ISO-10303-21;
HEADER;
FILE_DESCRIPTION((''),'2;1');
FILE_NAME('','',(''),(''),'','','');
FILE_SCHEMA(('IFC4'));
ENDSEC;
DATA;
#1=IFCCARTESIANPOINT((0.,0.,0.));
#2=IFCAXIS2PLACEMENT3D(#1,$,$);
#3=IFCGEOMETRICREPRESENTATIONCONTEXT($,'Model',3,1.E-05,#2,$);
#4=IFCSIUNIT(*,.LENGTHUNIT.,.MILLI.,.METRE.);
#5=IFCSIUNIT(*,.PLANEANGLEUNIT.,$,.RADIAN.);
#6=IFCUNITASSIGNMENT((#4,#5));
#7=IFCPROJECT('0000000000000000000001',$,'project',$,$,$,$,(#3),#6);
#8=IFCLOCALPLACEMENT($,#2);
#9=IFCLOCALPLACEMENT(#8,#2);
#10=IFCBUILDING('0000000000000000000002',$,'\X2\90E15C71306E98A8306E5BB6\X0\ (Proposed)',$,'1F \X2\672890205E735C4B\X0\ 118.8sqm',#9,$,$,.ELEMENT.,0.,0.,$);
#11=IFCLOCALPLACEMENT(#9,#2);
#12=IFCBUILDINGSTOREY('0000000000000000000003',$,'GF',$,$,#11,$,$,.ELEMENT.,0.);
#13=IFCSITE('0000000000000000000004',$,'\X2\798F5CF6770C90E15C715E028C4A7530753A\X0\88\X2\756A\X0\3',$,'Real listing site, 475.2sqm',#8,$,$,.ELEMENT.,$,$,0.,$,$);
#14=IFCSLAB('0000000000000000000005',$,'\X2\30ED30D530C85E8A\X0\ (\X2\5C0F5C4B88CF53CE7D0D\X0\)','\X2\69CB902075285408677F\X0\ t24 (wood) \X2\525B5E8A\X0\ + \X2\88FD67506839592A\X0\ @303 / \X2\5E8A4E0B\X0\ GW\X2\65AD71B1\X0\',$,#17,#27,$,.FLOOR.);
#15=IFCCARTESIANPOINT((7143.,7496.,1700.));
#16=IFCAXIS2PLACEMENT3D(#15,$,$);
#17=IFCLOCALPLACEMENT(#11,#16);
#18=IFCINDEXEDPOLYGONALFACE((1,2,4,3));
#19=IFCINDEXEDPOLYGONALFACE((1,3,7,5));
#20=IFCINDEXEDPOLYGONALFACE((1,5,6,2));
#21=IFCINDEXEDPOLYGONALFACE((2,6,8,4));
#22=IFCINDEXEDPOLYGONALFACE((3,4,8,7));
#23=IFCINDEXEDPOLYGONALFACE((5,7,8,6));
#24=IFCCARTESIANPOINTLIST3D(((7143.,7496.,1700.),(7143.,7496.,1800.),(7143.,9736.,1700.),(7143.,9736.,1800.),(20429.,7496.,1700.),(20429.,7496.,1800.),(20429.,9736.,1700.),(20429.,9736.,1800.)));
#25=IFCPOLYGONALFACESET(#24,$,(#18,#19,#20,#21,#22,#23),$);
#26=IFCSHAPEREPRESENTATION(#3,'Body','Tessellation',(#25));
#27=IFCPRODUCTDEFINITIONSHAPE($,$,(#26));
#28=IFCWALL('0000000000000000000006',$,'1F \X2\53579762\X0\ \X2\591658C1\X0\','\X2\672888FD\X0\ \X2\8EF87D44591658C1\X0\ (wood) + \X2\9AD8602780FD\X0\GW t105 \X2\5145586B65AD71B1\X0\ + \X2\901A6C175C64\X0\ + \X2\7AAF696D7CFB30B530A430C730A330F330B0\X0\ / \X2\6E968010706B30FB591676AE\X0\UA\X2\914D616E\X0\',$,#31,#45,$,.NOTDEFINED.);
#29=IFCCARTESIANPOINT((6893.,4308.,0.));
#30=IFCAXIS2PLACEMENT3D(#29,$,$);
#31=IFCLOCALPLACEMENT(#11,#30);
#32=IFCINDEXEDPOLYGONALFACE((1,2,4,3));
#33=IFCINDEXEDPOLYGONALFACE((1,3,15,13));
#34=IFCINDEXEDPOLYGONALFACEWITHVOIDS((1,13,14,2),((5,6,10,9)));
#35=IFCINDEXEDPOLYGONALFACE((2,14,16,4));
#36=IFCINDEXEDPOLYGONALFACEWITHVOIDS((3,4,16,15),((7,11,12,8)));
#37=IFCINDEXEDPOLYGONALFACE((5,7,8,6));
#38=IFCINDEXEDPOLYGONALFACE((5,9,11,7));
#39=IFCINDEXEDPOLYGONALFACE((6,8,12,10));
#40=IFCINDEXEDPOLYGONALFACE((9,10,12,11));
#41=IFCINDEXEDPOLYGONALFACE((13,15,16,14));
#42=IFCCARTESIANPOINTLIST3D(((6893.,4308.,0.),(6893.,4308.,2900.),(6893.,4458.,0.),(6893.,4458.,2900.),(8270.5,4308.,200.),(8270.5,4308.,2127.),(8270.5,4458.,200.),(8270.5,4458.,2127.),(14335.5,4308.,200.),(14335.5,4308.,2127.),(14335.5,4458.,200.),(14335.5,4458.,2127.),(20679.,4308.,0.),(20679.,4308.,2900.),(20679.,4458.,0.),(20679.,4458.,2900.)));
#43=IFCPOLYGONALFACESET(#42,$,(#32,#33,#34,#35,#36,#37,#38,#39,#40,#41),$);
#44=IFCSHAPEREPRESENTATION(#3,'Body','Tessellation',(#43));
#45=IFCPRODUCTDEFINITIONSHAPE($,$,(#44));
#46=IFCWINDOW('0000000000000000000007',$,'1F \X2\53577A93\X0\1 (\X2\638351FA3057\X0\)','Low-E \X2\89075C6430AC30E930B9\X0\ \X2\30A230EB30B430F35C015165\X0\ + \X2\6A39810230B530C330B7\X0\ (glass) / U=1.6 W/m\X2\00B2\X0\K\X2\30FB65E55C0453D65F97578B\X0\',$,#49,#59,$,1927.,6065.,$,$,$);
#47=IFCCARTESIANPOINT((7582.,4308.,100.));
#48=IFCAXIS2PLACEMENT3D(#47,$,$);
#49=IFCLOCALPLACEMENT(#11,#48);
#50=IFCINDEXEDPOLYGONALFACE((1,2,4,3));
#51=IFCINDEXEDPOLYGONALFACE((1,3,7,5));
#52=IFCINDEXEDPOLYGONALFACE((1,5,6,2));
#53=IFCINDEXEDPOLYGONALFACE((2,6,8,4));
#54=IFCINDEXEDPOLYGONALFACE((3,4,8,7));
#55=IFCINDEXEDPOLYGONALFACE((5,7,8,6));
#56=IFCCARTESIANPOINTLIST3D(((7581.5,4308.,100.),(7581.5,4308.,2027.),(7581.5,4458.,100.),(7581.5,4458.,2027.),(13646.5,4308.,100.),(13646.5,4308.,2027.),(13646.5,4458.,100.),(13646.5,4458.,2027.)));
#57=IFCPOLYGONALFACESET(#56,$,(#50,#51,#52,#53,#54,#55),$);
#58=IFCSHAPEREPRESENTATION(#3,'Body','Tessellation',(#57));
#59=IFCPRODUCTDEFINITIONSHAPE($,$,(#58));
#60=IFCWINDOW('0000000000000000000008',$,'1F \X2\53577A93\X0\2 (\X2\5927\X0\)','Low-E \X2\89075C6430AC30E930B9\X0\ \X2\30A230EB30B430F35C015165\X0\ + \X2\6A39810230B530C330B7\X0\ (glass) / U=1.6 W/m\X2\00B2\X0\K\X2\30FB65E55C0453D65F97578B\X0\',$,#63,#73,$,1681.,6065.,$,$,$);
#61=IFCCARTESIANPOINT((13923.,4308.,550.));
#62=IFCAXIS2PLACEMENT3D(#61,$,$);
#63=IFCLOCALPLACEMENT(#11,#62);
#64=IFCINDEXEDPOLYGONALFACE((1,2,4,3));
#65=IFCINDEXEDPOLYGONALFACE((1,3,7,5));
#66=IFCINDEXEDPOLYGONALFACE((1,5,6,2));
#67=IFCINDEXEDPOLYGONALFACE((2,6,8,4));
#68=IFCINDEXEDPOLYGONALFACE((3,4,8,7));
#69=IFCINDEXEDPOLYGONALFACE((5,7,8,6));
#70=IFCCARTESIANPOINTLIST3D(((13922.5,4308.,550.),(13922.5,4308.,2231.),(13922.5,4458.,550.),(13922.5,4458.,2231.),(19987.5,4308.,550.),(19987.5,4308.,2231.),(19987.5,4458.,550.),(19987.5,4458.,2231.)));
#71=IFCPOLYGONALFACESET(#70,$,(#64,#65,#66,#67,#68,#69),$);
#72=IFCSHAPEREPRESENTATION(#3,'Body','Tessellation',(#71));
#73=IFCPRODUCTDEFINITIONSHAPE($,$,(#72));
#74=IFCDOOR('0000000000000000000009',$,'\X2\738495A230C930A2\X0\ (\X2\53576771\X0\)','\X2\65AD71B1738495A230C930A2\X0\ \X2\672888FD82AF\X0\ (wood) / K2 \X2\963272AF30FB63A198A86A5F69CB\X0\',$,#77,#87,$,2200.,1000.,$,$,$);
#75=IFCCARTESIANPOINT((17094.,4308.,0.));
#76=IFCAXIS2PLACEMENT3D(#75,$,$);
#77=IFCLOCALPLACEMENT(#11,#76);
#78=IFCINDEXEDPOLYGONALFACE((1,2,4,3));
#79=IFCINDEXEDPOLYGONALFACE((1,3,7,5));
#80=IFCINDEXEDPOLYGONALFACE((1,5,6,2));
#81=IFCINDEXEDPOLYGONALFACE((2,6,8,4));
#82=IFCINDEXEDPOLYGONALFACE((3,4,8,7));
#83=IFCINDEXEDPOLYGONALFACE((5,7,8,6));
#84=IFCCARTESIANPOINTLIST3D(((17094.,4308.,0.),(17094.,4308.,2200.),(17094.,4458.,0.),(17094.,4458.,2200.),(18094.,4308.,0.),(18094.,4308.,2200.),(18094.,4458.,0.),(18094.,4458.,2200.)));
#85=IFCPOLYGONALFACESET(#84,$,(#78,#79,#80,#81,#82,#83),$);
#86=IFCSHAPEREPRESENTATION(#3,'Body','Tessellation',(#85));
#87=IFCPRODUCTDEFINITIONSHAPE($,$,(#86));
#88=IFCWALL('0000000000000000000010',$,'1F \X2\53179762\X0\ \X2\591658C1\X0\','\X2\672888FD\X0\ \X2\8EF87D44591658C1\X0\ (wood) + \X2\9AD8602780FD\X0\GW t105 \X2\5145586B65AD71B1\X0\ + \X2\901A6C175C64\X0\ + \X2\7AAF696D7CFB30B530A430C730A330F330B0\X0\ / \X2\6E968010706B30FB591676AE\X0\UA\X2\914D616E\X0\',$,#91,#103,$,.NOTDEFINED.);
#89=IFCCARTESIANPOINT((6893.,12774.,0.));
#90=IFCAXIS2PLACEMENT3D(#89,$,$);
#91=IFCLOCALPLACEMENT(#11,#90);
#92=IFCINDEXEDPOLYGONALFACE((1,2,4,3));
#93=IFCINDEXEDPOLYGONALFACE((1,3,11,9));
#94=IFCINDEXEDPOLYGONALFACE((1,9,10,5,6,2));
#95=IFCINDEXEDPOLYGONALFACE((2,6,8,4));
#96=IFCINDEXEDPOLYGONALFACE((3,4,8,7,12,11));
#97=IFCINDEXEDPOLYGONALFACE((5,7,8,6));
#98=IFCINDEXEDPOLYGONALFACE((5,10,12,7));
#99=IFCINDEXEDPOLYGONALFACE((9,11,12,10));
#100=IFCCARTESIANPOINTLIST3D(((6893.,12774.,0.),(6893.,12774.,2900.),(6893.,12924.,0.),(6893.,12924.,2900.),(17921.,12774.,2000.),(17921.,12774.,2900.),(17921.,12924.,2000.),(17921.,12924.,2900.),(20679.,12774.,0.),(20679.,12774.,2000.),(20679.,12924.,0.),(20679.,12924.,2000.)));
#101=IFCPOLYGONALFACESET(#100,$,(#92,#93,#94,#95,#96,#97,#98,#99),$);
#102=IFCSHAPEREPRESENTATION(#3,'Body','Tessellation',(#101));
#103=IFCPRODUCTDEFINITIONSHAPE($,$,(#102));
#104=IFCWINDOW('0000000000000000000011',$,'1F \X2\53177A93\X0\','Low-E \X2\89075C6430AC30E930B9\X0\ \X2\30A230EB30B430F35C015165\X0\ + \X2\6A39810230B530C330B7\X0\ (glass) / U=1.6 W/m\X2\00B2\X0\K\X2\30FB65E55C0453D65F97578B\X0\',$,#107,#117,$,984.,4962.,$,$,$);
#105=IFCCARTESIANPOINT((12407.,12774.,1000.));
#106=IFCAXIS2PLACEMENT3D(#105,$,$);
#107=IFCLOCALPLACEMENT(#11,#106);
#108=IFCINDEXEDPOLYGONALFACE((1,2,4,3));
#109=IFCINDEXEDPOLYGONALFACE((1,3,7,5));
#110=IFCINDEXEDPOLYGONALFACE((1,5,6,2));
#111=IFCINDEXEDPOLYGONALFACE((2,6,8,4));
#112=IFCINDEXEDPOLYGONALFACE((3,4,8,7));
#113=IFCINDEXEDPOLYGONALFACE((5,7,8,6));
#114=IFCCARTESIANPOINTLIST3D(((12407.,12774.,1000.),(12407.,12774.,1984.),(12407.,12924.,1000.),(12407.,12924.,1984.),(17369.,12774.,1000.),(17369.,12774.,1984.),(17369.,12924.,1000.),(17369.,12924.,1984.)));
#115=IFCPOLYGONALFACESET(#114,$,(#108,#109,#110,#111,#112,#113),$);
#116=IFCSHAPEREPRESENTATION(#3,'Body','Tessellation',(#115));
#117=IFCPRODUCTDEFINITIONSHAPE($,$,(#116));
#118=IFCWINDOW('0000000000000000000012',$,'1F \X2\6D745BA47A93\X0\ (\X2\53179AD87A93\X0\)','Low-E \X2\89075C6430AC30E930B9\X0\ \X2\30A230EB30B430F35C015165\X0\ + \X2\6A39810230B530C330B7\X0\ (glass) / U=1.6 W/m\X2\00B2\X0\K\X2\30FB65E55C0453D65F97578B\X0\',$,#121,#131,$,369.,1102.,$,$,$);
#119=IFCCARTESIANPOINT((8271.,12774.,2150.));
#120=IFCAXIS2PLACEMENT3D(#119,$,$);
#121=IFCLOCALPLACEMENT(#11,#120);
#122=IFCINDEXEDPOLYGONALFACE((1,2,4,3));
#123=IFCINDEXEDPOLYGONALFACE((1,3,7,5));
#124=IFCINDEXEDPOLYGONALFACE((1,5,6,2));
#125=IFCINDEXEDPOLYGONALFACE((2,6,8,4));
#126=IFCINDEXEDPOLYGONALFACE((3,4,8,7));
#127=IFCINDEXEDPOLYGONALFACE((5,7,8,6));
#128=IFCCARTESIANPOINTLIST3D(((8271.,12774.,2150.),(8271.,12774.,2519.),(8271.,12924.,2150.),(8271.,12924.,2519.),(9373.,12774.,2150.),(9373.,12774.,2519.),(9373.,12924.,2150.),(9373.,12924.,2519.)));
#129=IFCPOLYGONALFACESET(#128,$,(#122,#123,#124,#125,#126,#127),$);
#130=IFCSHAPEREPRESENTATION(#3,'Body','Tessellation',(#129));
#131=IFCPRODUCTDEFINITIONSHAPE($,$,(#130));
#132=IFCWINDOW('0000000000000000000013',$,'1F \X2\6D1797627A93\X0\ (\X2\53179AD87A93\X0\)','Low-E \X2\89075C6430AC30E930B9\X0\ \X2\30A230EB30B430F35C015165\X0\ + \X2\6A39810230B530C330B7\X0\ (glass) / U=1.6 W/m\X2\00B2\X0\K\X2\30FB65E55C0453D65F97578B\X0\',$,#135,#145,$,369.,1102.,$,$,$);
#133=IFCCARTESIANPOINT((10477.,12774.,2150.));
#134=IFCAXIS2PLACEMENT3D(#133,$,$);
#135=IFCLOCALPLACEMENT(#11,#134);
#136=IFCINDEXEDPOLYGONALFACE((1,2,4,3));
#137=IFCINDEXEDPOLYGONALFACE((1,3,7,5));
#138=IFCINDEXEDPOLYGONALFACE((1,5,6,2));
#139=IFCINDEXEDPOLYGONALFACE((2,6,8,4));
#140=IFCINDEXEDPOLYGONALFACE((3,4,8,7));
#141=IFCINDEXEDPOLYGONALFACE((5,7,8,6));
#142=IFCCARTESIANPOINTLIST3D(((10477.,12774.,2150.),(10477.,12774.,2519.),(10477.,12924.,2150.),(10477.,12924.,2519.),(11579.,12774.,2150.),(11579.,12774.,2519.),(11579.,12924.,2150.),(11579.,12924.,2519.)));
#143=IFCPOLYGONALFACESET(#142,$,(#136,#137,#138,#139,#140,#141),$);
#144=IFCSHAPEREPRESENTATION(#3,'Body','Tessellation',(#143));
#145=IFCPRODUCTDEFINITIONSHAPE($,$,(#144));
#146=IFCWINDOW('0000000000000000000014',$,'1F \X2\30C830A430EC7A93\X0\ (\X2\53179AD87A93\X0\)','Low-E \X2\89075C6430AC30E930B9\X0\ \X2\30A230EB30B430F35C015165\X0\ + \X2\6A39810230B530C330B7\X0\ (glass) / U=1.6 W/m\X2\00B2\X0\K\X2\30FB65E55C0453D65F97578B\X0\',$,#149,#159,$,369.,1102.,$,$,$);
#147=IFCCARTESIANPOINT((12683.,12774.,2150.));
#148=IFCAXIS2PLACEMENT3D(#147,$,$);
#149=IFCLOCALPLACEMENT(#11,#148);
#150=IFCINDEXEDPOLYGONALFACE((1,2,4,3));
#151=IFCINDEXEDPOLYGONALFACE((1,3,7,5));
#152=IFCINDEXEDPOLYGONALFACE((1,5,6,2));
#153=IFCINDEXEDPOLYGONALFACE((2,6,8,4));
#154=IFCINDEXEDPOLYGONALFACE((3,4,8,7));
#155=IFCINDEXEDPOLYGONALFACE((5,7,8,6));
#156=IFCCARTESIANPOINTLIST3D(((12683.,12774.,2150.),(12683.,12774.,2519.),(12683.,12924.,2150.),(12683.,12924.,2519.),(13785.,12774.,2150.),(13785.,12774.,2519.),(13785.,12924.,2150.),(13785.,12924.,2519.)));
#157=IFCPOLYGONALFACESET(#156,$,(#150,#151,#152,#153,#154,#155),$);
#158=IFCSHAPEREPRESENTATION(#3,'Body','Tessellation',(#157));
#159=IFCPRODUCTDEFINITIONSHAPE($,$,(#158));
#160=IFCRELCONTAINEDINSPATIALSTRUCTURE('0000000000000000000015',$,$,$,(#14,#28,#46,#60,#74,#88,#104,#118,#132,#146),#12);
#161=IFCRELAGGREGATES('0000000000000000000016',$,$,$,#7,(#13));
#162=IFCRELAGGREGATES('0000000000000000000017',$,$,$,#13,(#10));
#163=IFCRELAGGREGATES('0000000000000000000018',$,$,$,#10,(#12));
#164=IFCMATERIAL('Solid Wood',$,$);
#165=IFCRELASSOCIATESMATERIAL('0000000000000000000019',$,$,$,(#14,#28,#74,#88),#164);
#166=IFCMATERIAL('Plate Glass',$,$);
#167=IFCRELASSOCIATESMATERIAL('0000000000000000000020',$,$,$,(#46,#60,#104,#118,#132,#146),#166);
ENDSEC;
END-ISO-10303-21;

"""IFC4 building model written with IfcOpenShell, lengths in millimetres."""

from ifc_helpers import new_model, si_unit, frame, frame_2d, origin, place, context, project, spatial, rectangle, extrude, material, element, fill, save


model = new_model("IFC4")

# Units and contexts
model_context = context("Model", 3, precision=1e-05, world=origin())
ifc_project = project(units=[si_unit("LENGTHUNIT", "METRE", prefix="MILLI"), si_unit("PLANEANGLEUNIT", "RADIAN")], contexts=[model_context])

# Site, building, storey
site_placement = place(None, origin())
site = spatial("IfcSite", under=ifc_project, at=site_placement, Name="福島県郡山市豊田町88番3", ObjectType="Real listing site, 475.2sqm", CompositionType="ELEMENT", RefElevation=0.0)
building_placement = place(site_placement, origin())
building = spatial("IfcBuilding", under=site, at=building_placement, Name="郡山の風の家 (Proposed)", ObjectType="1F 木造平屋 118.8sqm", CompositionType="ELEMENT", ElevationOfRefHeight=0.0, ElevationOfTerrain=0.0)
storey_placement = place(building_placement, origin())
storey = spatial("IfcBuildingStorey", under=building, at=storey_placement, Name="GF", CompositionType="ELEMENT", Elevation=0.0)

# Slab
ifc_material_1 = material(Name="Solid Wood")
slab_1_placement = place(storey_placement, frame((7143.0, 7496.0, 1700.0)))
element("IfcSlab", 1, at=slab_1_placement, inside=storey, material=ifc_material_1, Name="ロフト床 (小屋裏収納)", Description="構造用合板 t24 (wood) 剛床 + 製材根太 @303 / 床下 GW断熱", PredefinedType="FLOOR", context=model_context, shape_type="SweptSolid", body=[
    extrude(rectangle(XDim=13286.0, YDim=2240.0, at=frame_2d((6643.0, 1120.0))), frame((7143.0, 7496.0, 1700.0)), (0.0, 0.0, 1.0), 100.0),
])

# Wall, openings, windows, door
wall_1_placement = place(storey_placement, frame((6893.0, 4308.0, 0.0)))
wall_1 = element("IfcWall", 2, at=wall_1_placement, inside=storey, material=ifc_material_1, Name="1F 南面 外壁", Description="木製 軸組外壁 (wood) + 高性能GW t105 充填断熱 + 通気層 + 窯業系サイディング / 準耐火・外皮UA配慮", PredefinedType="NOTDEFINED", context=model_context, shape_type="SweptSolid", body=[
    extrude(rectangle(XDim=13786.0, YDim=150.0, at=frame_2d((6893.0, 75.0))), frame((6893.0, 4308.0, 0.0)), (0.0, 0.0, 1.0), 2900.0),
])
opening_1_placement = place(storey_placement, frame((7582.0, 4308.0, 100.0)))
opening_1 = element("IfcOpeningElement", 3, at=opening_1_placement, cuts=wall_1, PredefinedType="NOTDEFINED", context=model_context, shape_type="SweptSolid", body=[
    extrude(rectangle(XDim=6065.0, YDim=150.0, at=frame_2d((3032.0, 75.0))), frame((7582.0, 4308.0, 100.0)), (0.0, 0.0, 1.0), 1927.0),
])
opening_2_placement = place(storey_placement, frame((13923.0, 4308.0, 550.0)))
opening_2 = element("IfcOpeningElement", 4, at=opening_2_placement, cuts=wall_1, PredefinedType="NOTDEFINED", context=model_context, shape_type="SweptSolid", body=[
    extrude(rectangle(XDim=6065.0, YDim=150.0, at=frame_2d((3032.0, 75.0))), frame((13923.0, 4308.0, 550.0)), (0.0, 0.0, 1.0), 1681.0),
])
opening_3_placement = place(storey_placement, frame((17094.0, 4308.0, 0.0)))
opening_3 = element("IfcOpeningElement", 5, at=opening_3_placement, cuts=wall_1, PredefinedType="NOTDEFINED", context=model_context, shape_type="SweptSolid", body=[
    extrude(rectangle(XDim=1000.0, YDim=150.0, at=frame_2d((500.0, 75.0))), frame((17094.0, 4308.0, 0.0)), (0.0, 0.0, 1.0), 2200.0),
])
ifc_material_2 = material(Name="Plate Glass")
window_1_placement = place(storey_placement, frame((7582.0, 4308.0, 100.0)))
window_1 = element("IfcWindow", 6, at=window_1_placement, inside=storey, material=ifc_material_2, Name="1F 南窓1 (掃出し)", Description="Low-E 複層ガラス アルゴン封入 + 樹脂サッシ (glass) / U=1.6 W/m²K・日射取得型", OverallHeight=1927.0, OverallWidth=6065.0, context=model_context, shape_type="SweptSolid", body=[
    extrude(rectangle(XDim=6065.0, YDim=150.0, at=frame_2d((3032.0, 75.0))), frame((7582.0, 4308.0, 100.0)), (0.0, 0.0, 1.0), 1927.0),
])
fill(opening_1, window_1)
window_2_placement = place(storey_placement, frame((13923.0, 4308.0, 550.0)))
window_2 = element("IfcWindow", 7, at=window_2_placement, inside=storey, material=ifc_material_2, Name="1F 南窓2 (大)", Description="Low-E 複層ガラス アルゴン封入 + 樹脂サッシ (glass) / U=1.6 W/m²K・日射取得型", OverallHeight=1681.0, OverallWidth=6065.0, context=model_context, shape_type="SweptSolid", body=[
    extrude(rectangle(XDim=6065.0, YDim=150.0, at=frame_2d((3032.0, 75.0))), frame((13923.0, 4308.0, 550.0)), (0.0, 0.0, 1.0), 1681.0),
])
fill(opening_2, window_2)
door_1_placement = place(storey_placement, frame((17094.0, 4308.0, 0.0)))
door_1 = element("IfcDoor", 8, at=door_1_placement, inside=storey, material=ifc_material_1, Name="玄関ドア (南東)", Description="断熱玄関ドア 木製芯 (wood) / K2 防犯・採風機構", OverallHeight=2200.0, OverallWidth=1000.0, context=model_context, shape_type="SweptSolid", body=[
    extrude(rectangle(XDim=1000.0, YDim=150.0, at=frame_2d((500.0, 75.0))), frame((17094.0, 4308.0, 0.0)), (0.0, 0.0, 1.0), 2200.0),
])
fill(opening_3, door_1)

# Wall, openings, windows
wall_2_placement = place(storey_placement, frame((6893.0, 12774.0, 0.0)))
wall_2 = element("IfcWall", 9, at=wall_2_placement, inside=storey, material=ifc_material_1, Name="1F 北面 外壁", Description="木製 軸組外壁 (wood) + 高性能GW t105 充填断熱 + 通気層 + 窯業系サイディング / 準耐火・外皮UA配慮", PredefinedType="NOTDEFINED", context=model_context, shape_type="SweptSolid", body=[
    extrude(rectangle(XDim=13786.0, YDim=150.0, at=frame_2d((6893.0, 75.0))), frame((6893.0, 12774.0, 0.0)), (0.0, 0.0, 1.0), 2900.0),
])
opening_4_placement = place(storey_placement, frame((12407.0, 12774.0, 1000.0)))
opening_4 = element("IfcOpeningElement", 10, at=opening_4_placement, cuts=wall_2, PredefinedType="NOTDEFINED", context=model_context, shape_type="SweptSolid", body=[
    extrude(rectangle(XDim=4962.0, YDim=150.0, at=frame_2d((2481.0, 75.0))), frame((12407.0, 12774.0, 1000.0)), (0.0, 0.0, 1.0), 984.0),
])
opening_5_placement = place(storey_placement, frame((8271.0, 12774.0, 2150.0)))
opening_5 = element("IfcOpeningElement", 11, at=opening_5_placement, cuts=wall_2, PredefinedType="NOTDEFINED", context=model_context, shape_type="SweptSolid", body=[
    extrude(rectangle(XDim=1102.0, YDim=150.0, at=frame_2d((551.0, 75.0))), frame((8271.0, 12774.0, 2150.0)), (0.0, 0.0, 1.0), 369.0),
])
opening_6_placement = place(storey_placement, frame((10477.0, 12774.0, 2150.0)))
opening_6 = element("IfcOpeningElement", 12, at=opening_6_placement, cuts=wall_2, PredefinedType="NOTDEFINED", context=model_context, shape_type="SweptSolid", body=[
    extrude(rectangle(XDim=1102.0, YDim=150.0, at=frame_2d((551.0, 75.0))), frame((10477.0, 12774.0, 2150.0)), (0.0, 0.0, 1.0), 369.0),
])
opening_7_placement = place(storey_placement, frame((12683.0, 12774.0, 2150.0)))
opening_7 = element("IfcOpeningElement", 13, at=opening_7_placement, cuts=wall_2, PredefinedType="NOTDEFINED", context=model_context, shape_type="SweptSolid", body=[
    extrude(rectangle(XDim=1102.0, YDim=150.0, at=frame_2d((551.0, 75.0))), frame((12683.0, 12774.0, 2150.0)), (0.0, 0.0, 1.0), 369.0),
])
window_3_placement = place(storey_placement, frame((12407.0, 12774.0, 1000.0)))
window_3 = element("IfcWindow", 14, at=window_3_placement, inside=storey, material=ifc_material_2, Name="1F 北窓", Description="Low-E 複層ガラス アルゴン封入 + 樹脂サッシ (glass) / U=1.6 W/m²K・日射取得型", OverallHeight=984.0, OverallWidth=4962.0, context=model_context, shape_type="SweptSolid", body=[
    extrude(rectangle(XDim=4962.0, YDim=150.0, at=frame_2d((2481.0, 75.0))), frame((12407.0, 12774.0, 1000.0)), (0.0, 0.0, 1.0), 984.0),
])
fill(opening_4, window_3)
window_4_placement = place(storey_placement, frame((8271.0, 12774.0, 2150.0)))
window_4 = element("IfcWindow", 15, at=window_4_placement, inside=storey, material=ifc_material_2, Name="1F 浴室窓 (北高窓)", Description="Low-E 複層ガラス アルゴン封入 + 樹脂サッシ (glass) / U=1.6 W/m²K・日射取得型", OverallHeight=369.0, OverallWidth=1102.0, context=model_context, shape_type="SweptSolid", body=[
    extrude(rectangle(XDim=1102.0, YDim=150.0, at=frame_2d((551.0, 75.0))), frame((8271.0, 12774.0, 2150.0)), (0.0, 0.0, 1.0), 369.0),
])
fill(opening_5, window_4)
window_5_placement = place(storey_placement, frame((10477.0, 12774.0, 2150.0)))
window_5 = element("IfcWindow", 16, at=window_5_placement, inside=storey, material=ifc_material_2, Name="1F 洗面窓 (北高窓)", Description="Low-E 複層ガラス アルゴン封入 + 樹脂サッシ (glass) / U=1.6 W/m²K・日射取得型", OverallHeight=369.0, OverallWidth=1102.0, context=model_context, shape_type="SweptSolid", body=[
    extrude(rectangle(XDim=1102.0, YDim=150.0, at=frame_2d((551.0, 75.0))), frame((10477.0, 12774.0, 2150.0)), (0.0, 0.0, 1.0), 369.0),
])
fill(opening_6, window_5)
window_6_placement = place(storey_placement, frame((12683.0, 12774.0, 2150.0)))
window_6 = element("IfcWindow", 17, at=window_6_placement, inside=storey, material=ifc_material_2, Name="1F トイレ窓 (北高窓)", Description="Low-E 複層ガラス アルゴン封入 + 樹脂サッシ (glass) / U=1.6 W/m²K・日射取得型", OverallHeight=369.0, OverallWidth=1102.0, context=model_context, shape_type="SweptSolid", body=[
    extrude(rectangle(XDim=1102.0, YDim=150.0, at=frame_2d((551.0, 75.0))), frame((12683.0, 12774.0, 2150.0)), (0.0, 0.0, 1.0), 369.0),
])
fill(opening_7, window_6)

save(model, "model.ifc")
